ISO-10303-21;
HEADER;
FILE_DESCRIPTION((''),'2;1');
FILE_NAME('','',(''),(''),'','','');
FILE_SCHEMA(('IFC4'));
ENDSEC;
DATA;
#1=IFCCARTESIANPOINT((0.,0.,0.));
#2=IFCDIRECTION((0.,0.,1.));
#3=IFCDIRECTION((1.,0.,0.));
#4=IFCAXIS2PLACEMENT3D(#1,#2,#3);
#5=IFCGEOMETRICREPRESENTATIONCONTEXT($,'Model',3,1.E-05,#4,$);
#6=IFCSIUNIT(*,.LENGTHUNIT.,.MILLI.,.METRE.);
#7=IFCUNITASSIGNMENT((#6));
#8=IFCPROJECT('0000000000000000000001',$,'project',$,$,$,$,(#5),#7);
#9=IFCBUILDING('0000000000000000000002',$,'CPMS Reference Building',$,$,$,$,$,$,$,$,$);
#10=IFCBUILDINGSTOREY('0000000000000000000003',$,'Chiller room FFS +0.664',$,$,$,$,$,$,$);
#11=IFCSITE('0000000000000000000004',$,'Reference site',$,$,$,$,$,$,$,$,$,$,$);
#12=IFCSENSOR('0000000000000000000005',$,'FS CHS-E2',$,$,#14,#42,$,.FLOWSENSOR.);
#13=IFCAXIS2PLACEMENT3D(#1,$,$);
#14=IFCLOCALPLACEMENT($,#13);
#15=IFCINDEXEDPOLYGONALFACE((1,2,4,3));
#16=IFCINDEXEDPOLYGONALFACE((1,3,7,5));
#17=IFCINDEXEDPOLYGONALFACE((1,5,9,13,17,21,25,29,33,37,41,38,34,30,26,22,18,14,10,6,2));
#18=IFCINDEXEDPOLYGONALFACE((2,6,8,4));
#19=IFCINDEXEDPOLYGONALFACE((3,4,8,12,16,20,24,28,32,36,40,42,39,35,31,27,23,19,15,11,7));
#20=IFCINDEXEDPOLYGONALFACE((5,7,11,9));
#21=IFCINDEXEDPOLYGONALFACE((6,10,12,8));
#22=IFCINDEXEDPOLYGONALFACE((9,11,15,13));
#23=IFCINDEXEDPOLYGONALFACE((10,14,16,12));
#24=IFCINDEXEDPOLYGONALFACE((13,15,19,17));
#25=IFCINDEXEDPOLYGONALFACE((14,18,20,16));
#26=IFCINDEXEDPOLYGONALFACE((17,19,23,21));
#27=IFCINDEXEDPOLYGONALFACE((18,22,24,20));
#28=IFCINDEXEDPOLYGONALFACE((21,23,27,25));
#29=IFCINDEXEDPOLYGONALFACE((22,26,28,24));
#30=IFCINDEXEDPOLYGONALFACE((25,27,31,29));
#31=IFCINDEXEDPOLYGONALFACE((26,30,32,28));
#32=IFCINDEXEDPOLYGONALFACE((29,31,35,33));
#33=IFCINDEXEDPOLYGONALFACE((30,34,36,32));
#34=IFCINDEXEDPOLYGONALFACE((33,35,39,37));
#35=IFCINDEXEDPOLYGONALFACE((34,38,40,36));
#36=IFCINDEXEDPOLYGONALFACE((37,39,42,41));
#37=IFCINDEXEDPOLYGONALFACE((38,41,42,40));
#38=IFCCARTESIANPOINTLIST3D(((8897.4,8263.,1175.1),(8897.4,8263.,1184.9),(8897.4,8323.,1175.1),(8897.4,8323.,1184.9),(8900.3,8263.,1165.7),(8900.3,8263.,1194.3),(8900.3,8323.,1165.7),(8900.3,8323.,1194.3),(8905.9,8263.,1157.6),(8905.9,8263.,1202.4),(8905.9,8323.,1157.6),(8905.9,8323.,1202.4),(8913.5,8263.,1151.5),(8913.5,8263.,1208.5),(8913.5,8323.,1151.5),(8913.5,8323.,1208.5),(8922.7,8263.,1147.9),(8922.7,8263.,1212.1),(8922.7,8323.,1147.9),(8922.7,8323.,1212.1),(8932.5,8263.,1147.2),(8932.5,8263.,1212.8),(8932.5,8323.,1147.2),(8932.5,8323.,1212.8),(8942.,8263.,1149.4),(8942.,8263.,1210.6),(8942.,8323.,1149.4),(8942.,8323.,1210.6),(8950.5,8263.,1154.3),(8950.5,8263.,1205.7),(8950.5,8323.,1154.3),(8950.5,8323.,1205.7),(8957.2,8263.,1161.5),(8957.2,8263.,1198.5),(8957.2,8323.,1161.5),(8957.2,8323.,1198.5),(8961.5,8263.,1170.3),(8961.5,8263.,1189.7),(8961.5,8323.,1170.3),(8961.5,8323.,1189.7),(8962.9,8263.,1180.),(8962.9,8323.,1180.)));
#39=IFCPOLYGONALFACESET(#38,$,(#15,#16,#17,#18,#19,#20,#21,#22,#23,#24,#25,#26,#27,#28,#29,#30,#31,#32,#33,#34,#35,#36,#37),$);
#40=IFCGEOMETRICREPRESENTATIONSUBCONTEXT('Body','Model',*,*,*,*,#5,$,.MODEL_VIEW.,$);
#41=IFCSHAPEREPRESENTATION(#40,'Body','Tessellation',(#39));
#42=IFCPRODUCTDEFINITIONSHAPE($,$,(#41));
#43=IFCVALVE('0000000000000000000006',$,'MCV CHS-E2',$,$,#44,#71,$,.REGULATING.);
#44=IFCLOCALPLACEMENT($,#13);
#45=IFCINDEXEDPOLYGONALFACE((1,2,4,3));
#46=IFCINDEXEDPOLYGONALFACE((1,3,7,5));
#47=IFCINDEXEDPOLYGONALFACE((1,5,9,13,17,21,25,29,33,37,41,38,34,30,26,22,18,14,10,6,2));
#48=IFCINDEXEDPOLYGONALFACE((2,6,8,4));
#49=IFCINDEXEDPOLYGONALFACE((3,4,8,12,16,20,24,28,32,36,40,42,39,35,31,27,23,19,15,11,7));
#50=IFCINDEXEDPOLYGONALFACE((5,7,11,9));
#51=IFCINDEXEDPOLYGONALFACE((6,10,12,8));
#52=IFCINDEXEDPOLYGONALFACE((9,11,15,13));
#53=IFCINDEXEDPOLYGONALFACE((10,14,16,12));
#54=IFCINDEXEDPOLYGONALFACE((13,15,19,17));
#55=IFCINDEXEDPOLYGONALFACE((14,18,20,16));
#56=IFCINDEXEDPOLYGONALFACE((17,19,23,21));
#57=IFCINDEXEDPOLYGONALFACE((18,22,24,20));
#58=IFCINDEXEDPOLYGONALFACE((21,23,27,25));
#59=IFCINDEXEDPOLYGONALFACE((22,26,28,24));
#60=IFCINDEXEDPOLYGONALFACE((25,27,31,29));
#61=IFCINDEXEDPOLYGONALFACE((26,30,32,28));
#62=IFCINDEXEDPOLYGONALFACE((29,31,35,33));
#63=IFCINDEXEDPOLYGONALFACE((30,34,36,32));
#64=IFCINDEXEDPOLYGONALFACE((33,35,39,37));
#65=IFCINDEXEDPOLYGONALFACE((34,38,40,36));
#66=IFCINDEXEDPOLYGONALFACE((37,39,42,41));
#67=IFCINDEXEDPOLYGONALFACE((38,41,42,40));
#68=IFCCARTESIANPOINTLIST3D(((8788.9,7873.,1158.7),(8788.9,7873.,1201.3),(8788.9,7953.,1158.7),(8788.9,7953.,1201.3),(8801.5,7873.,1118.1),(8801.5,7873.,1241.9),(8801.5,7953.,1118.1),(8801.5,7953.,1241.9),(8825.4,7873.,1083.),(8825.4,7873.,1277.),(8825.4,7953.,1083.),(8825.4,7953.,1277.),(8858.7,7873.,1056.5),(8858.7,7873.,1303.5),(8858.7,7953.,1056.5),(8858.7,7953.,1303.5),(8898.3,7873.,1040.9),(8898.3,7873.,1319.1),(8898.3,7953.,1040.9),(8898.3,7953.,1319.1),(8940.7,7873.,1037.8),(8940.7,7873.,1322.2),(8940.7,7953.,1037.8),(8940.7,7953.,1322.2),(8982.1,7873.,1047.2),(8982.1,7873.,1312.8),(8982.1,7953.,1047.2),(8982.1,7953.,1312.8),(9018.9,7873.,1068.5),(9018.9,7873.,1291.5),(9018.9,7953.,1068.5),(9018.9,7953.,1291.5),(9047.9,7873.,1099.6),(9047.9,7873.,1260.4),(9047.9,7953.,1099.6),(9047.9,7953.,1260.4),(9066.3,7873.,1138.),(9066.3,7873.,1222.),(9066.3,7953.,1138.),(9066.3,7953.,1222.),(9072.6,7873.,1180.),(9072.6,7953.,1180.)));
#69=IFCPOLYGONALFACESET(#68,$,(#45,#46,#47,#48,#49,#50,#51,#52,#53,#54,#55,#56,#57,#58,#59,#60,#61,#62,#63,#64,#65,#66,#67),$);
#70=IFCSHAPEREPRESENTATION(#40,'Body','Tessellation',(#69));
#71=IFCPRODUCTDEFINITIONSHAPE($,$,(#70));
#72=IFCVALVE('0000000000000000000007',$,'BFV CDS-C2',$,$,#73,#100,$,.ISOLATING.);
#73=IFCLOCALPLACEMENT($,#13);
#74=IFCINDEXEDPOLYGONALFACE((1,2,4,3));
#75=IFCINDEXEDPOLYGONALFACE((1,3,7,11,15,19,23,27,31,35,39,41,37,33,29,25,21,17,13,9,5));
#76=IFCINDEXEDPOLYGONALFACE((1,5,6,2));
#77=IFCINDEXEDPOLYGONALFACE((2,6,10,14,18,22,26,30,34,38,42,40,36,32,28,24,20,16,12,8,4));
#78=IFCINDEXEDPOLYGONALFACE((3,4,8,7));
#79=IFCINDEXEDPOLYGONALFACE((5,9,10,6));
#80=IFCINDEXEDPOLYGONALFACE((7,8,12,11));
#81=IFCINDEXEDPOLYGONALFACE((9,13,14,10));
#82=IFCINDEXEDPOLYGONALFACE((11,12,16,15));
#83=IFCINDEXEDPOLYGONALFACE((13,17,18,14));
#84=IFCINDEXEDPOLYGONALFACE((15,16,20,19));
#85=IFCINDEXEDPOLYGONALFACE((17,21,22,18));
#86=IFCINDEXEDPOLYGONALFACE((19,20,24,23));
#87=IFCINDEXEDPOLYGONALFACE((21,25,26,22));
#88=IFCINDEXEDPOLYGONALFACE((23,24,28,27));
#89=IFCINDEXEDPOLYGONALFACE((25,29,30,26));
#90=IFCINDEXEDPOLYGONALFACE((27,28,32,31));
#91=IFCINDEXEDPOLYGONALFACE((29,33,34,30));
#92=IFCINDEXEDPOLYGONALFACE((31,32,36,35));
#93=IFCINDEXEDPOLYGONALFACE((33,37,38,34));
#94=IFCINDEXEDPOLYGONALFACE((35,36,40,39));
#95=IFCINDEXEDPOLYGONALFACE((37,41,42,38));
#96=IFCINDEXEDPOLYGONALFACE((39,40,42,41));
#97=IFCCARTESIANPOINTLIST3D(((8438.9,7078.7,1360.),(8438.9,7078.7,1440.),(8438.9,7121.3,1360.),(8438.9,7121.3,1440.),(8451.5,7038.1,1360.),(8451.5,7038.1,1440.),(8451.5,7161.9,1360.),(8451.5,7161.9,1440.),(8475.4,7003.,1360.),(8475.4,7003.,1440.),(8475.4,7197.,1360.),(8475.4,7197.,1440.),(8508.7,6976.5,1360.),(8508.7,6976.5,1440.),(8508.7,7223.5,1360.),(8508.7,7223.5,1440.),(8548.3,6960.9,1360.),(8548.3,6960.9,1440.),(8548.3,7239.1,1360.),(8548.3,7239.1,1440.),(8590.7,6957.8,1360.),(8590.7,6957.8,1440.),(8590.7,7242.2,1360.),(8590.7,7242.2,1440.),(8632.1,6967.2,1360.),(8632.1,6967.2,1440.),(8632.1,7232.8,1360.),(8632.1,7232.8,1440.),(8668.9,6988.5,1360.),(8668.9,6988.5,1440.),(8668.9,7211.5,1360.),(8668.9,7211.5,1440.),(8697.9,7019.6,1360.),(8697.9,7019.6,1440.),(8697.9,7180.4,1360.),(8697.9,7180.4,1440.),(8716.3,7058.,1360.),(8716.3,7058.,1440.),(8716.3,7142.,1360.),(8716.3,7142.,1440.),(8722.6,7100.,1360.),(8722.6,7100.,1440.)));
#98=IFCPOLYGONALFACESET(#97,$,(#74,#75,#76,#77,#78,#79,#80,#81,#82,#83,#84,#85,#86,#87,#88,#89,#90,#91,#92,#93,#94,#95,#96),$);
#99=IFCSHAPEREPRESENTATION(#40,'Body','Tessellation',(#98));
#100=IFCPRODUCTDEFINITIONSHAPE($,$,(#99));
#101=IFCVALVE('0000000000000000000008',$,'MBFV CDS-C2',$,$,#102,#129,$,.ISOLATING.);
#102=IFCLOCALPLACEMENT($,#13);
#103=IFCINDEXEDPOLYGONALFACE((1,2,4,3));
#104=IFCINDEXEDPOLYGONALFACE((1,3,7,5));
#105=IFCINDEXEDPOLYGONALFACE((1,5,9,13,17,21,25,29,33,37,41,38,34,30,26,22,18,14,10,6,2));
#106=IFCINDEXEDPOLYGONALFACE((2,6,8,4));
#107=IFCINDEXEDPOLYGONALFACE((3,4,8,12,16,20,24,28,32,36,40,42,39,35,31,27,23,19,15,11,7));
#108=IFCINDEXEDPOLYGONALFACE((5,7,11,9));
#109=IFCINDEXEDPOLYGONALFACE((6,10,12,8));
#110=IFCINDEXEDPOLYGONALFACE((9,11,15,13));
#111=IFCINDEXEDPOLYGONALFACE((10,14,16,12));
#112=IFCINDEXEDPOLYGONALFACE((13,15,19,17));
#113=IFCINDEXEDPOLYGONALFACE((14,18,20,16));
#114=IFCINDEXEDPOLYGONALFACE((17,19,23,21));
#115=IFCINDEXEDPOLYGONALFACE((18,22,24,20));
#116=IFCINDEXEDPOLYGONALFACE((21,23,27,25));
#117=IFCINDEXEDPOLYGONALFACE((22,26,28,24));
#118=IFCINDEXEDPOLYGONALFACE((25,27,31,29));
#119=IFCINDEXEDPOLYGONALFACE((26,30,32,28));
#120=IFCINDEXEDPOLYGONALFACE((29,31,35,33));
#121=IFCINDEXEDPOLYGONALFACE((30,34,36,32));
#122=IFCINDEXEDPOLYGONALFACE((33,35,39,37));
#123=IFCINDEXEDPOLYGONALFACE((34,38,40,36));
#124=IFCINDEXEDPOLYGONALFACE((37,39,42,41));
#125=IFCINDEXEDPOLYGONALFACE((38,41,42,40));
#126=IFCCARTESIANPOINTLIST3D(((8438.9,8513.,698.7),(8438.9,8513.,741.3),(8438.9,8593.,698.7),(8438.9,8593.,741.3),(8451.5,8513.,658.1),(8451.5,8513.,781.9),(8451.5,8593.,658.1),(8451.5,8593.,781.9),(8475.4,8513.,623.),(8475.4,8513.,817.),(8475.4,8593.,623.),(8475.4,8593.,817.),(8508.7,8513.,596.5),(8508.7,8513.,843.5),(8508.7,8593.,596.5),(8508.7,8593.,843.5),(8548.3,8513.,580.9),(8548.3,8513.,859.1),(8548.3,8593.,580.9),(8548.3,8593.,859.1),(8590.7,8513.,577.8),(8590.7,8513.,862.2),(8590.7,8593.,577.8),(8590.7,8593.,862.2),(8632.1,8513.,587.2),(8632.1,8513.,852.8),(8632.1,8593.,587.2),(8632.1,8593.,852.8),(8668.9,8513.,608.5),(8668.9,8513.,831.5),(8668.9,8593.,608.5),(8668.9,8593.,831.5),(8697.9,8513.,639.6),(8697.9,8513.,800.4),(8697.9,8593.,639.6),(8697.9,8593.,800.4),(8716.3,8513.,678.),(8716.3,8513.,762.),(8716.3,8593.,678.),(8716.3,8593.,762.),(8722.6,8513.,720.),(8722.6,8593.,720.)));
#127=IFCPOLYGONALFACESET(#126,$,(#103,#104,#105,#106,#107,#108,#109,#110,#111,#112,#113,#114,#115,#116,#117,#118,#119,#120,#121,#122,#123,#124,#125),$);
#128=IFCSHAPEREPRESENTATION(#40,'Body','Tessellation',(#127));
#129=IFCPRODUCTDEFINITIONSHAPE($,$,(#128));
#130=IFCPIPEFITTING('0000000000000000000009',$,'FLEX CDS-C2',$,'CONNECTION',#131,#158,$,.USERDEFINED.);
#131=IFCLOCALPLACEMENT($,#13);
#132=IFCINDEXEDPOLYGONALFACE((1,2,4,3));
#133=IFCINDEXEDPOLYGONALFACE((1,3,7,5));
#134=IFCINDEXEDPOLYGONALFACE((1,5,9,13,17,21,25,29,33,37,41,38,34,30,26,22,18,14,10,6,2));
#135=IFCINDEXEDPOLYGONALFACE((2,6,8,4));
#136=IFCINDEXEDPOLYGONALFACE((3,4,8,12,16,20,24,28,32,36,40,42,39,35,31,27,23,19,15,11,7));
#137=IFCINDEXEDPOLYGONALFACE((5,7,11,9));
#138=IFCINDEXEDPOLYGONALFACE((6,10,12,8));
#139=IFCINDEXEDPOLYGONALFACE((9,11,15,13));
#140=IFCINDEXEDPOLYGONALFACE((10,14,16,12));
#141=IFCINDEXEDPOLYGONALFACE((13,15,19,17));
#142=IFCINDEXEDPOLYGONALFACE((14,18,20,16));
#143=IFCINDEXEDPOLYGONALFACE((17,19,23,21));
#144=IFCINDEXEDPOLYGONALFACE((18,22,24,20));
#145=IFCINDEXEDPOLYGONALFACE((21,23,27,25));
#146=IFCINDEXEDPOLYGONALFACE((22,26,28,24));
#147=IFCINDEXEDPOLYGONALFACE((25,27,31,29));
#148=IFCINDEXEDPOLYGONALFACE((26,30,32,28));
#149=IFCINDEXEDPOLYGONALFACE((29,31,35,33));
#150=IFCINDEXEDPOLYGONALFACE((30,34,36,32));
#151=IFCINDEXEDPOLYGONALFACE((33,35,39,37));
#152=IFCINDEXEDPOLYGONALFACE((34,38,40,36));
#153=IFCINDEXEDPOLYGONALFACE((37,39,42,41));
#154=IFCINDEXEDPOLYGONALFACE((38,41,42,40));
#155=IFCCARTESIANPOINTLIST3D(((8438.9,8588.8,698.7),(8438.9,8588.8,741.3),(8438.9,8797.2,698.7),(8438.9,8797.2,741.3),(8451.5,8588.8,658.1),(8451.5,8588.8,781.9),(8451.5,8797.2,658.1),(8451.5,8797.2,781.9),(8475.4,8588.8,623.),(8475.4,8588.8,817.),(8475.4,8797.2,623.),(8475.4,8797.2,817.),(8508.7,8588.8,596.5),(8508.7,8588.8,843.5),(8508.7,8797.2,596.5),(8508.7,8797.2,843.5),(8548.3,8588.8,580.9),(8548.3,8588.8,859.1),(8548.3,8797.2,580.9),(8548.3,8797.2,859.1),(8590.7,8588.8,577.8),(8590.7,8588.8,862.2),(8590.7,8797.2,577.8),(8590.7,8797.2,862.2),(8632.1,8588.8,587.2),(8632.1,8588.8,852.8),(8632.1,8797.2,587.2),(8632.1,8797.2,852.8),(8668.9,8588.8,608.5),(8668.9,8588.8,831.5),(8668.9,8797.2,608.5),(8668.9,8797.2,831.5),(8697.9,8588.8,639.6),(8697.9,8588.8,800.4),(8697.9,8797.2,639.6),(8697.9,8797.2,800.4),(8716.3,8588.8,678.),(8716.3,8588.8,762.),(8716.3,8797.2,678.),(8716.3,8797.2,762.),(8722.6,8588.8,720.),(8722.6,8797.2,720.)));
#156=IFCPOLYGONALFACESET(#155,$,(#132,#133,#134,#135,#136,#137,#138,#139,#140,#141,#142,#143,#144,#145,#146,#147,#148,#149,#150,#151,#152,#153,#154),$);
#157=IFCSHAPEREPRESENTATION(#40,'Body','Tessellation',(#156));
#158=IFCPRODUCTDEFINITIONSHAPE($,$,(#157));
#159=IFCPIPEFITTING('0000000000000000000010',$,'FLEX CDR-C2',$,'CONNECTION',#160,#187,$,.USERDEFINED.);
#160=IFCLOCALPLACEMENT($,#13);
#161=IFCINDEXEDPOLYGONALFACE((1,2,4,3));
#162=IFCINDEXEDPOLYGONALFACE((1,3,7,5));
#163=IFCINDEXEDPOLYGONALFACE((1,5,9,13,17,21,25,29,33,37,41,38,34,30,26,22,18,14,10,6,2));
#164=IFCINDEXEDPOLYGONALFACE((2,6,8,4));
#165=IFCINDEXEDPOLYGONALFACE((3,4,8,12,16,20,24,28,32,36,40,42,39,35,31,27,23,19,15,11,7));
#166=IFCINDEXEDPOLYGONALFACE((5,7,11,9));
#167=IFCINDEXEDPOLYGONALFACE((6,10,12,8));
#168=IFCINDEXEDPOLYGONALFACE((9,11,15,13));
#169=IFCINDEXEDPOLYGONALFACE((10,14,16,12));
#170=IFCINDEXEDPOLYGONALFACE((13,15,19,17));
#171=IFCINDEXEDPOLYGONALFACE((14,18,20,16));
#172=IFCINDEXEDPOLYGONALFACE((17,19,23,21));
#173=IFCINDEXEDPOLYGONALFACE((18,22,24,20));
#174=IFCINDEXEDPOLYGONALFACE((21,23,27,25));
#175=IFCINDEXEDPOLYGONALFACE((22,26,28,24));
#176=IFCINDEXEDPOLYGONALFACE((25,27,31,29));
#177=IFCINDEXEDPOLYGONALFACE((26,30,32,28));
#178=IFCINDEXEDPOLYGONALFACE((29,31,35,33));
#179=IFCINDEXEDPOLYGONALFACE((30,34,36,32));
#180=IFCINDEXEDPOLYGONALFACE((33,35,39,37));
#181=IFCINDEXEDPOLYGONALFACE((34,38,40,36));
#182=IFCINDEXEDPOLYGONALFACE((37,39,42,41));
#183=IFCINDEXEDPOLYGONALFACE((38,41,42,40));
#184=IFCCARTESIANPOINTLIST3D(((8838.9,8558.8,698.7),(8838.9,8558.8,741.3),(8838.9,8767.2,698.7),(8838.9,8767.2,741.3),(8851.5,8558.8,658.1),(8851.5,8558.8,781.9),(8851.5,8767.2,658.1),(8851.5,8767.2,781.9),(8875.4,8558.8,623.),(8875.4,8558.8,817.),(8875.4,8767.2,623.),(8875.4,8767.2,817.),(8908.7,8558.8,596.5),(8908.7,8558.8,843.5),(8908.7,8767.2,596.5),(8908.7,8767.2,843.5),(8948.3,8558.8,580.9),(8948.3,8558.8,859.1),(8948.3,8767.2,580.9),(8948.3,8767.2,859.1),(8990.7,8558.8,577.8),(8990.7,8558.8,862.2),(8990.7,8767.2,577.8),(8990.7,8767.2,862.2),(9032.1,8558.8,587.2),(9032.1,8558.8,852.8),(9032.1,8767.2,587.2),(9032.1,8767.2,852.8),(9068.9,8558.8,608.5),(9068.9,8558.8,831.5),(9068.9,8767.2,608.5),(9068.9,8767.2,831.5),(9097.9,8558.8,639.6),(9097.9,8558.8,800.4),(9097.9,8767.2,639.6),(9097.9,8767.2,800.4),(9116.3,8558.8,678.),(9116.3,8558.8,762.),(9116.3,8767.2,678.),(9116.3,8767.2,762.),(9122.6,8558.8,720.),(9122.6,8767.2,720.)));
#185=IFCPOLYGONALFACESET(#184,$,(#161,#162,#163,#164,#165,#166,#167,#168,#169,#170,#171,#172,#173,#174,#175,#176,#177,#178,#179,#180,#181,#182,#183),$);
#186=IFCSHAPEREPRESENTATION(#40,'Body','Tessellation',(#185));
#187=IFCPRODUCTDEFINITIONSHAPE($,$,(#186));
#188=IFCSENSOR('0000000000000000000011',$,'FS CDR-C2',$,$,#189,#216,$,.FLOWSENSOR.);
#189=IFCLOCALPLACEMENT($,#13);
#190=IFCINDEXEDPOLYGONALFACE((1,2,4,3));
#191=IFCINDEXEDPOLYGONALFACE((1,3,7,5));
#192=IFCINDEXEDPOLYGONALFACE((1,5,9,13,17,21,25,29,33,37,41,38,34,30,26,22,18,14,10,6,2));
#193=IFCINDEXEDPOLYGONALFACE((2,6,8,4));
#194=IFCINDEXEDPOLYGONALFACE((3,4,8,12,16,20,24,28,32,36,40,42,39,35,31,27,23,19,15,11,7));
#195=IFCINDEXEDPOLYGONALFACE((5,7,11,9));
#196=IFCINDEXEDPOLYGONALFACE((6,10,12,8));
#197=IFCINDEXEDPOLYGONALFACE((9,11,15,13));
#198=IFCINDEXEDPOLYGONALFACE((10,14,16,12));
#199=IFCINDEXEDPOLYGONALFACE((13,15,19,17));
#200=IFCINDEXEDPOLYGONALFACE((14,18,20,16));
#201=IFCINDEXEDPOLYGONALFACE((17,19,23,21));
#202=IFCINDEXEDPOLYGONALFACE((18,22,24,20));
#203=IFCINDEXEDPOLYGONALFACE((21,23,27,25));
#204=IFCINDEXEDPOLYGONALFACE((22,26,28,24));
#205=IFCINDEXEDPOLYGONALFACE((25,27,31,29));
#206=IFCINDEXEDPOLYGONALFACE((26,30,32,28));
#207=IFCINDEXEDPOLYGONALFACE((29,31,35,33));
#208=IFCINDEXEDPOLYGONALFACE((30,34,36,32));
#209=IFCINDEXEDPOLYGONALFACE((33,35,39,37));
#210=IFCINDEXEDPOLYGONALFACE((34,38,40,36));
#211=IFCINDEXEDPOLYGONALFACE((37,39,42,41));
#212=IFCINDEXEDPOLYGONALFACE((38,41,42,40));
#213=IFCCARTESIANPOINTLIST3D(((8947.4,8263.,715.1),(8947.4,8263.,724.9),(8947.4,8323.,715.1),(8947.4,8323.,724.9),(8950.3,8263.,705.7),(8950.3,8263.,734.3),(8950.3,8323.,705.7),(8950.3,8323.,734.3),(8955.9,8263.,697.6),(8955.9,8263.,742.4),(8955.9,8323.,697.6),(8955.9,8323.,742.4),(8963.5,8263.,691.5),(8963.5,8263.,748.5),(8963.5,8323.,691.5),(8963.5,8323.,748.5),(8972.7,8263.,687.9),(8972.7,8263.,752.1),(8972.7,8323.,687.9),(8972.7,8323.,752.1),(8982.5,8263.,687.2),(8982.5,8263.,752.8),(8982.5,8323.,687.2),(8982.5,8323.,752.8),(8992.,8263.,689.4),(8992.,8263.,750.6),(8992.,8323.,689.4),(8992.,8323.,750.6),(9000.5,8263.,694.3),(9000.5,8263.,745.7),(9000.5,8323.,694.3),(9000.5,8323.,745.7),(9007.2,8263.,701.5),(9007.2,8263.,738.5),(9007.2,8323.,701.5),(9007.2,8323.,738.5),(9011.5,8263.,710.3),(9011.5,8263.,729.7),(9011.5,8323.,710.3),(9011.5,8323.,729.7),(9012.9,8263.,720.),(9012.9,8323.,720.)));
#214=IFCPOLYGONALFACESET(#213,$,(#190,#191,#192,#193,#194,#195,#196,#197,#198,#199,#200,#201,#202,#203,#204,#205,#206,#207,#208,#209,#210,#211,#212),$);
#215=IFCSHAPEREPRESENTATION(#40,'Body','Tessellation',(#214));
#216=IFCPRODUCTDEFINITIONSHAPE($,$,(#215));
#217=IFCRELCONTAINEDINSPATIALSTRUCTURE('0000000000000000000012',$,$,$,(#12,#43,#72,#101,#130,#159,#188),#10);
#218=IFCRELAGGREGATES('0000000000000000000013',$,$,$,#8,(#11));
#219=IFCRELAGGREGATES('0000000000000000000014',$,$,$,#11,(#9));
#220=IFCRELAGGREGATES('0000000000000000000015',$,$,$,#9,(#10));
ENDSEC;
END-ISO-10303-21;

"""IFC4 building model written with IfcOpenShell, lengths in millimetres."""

from ifc_helpers import new_model, si_unit, frame, origin_with_axes, origin_2d, place, context, subcontext, project, spatial, circle_curve, outline, extrude, element, save


model = new_model("IFC4")

# Units and contexts
model_context = context("Model", 3, precision=1e-05, world=origin_with_axes())
body_context = subcontext(model_context, "Body", "Model", "MODEL_VIEW")
ifc_project = project(units=[si_unit("LENGTHUNIT", "METRE", prefix="MILLI")], contexts=[model_context])

# Site, building, storey
site = spatial("IfcSite", under=ifc_project, Name="Reference site")
building = spatial("IfcBuilding", under=site, Name="CPMS Reference Building")
storey = spatial("IfcBuildingStorey", under=building, Name="Chiller room FFS +0.664")

# Sensor
sensor_1_placement = place(None, origin_with_axes())
element("IfcSensor", 1, at=sensor_1_placement, inside=storey, Name="FS CHS-E2", PredefinedType="FLOWSENSOR", context=body_context, shape_type="SweptSolid", body=[
    extrude(outline(circle_curve(origin_2d(), 32.9)), frame((8930.0, 8323.0, 1180.0), z_axis=(0.0, -1.0, 0.0), x_axis=(1.0, 0.0, 0.0)), (0.0, 0.0, 1.0), 60.0),
])

# Valves
valve_1_placement = place(None, origin_with_axes())
element("IfcValve", 2, at=valve_1_placement, inside=storey, Name="MCV CHS-E2", PredefinedType="REGULATING", context=body_context, shape_type="SweptSolid", body=[
    extrude(outline(circle_curve(origin_2d(), 142.6)), frame((8930.0, 7953.0, 1180.0), z_axis=(0.0, -1.0, 0.0), x_axis=(1.0, 0.0, 0.0)), (0.0, 0.0, 1.0), 80.0),
])
valve_2_placement = place(None, origin_with_axes())
element("IfcValve", 3, at=valve_2_placement, inside=storey, Name="BFV CDS-C2", PredefinedType="ISOLATING", context=body_context, shape_type="SweptSolid", body=[
    extrude(outline(circle_curve(origin_2d(), 142.6)), frame((8580.0, 7100.0, 1440.0), z_axis=(0.0, 0.0, -1.0), x_axis=(1.0, 0.0, 0.0)), (0.0, 0.0, 1.0), 80.0),
])
valve_3_placement = place(None, origin_with_axes())
element("IfcValve", 4, at=valve_3_placement, inside=storey, Name="MBFV CDS-C2", PredefinedType="ISOLATING", context=body_context, shape_type="SweptSolid", body=[
    extrude(outline(circle_curve(origin_2d(), 142.6)), frame((8580.0, 8513.0, 720.0), z_axis=(0.0, 1.0, 0.0), x_axis=(1.0, 0.0, 0.0)), (0.0, 0.0, 1.0), 80.0),
])

# Pipe fittings
pipe_fitting_1_placement = place(None, origin_with_axes())
element("IfcPipeFitting", 5, at=pipe_fitting_1_placement, inside=storey, Name="FLEX CDS-C2", ObjectType="CONNECTION", PredefinedType="USERDEFINED", context=body_context, shape_type="SweptSolid", body=[
    extrude(outline(circle_curve(origin_2d(), 142.6)), frame((8580.0, 8588.8, 720.0), z_axis=(0.0, 1.0, 0.0), x_axis=(1.0, 0.0, 0.0)), (0.0, 0.0, 1.0), 208.5),
])
pipe_fitting_2_placement = place(None, origin_with_axes())
element("IfcPipeFitting", 6, at=pipe_fitting_2_placement, inside=storey, Name="FLEX CDR-C2", ObjectType="CONNECTION", PredefinedType="USERDEFINED", context=body_context, shape_type="SweptSolid", body=[
    extrude(outline(circle_curve(origin_2d(), 142.6)), frame((8980.0, 8767.2, 720.0), z_axis=(0.0, -1.0, 0.0), x_axis=(1.0, 0.0, 0.0)), (0.0, 0.0, 1.0), 208.5),
])

# Sensor
sensor_2_placement = place(None, origin_with_axes())
element("IfcSensor", 7, at=sensor_2_placement, inside=storey, Name="FS CDR-C2", PredefinedType="FLOWSENSOR", context=body_context, shape_type="SweptSolid", body=[
    extrude(outline(circle_curve(origin_2d(), 32.9)), frame((8980.0, 8323.0, 720.0), z_axis=(0.0, -1.0, 0.0), x_axis=(1.0, 0.0, 0.0)), (0.0, 0.0, 1.0), 60.0),
])

save(model, "model.ifc")
